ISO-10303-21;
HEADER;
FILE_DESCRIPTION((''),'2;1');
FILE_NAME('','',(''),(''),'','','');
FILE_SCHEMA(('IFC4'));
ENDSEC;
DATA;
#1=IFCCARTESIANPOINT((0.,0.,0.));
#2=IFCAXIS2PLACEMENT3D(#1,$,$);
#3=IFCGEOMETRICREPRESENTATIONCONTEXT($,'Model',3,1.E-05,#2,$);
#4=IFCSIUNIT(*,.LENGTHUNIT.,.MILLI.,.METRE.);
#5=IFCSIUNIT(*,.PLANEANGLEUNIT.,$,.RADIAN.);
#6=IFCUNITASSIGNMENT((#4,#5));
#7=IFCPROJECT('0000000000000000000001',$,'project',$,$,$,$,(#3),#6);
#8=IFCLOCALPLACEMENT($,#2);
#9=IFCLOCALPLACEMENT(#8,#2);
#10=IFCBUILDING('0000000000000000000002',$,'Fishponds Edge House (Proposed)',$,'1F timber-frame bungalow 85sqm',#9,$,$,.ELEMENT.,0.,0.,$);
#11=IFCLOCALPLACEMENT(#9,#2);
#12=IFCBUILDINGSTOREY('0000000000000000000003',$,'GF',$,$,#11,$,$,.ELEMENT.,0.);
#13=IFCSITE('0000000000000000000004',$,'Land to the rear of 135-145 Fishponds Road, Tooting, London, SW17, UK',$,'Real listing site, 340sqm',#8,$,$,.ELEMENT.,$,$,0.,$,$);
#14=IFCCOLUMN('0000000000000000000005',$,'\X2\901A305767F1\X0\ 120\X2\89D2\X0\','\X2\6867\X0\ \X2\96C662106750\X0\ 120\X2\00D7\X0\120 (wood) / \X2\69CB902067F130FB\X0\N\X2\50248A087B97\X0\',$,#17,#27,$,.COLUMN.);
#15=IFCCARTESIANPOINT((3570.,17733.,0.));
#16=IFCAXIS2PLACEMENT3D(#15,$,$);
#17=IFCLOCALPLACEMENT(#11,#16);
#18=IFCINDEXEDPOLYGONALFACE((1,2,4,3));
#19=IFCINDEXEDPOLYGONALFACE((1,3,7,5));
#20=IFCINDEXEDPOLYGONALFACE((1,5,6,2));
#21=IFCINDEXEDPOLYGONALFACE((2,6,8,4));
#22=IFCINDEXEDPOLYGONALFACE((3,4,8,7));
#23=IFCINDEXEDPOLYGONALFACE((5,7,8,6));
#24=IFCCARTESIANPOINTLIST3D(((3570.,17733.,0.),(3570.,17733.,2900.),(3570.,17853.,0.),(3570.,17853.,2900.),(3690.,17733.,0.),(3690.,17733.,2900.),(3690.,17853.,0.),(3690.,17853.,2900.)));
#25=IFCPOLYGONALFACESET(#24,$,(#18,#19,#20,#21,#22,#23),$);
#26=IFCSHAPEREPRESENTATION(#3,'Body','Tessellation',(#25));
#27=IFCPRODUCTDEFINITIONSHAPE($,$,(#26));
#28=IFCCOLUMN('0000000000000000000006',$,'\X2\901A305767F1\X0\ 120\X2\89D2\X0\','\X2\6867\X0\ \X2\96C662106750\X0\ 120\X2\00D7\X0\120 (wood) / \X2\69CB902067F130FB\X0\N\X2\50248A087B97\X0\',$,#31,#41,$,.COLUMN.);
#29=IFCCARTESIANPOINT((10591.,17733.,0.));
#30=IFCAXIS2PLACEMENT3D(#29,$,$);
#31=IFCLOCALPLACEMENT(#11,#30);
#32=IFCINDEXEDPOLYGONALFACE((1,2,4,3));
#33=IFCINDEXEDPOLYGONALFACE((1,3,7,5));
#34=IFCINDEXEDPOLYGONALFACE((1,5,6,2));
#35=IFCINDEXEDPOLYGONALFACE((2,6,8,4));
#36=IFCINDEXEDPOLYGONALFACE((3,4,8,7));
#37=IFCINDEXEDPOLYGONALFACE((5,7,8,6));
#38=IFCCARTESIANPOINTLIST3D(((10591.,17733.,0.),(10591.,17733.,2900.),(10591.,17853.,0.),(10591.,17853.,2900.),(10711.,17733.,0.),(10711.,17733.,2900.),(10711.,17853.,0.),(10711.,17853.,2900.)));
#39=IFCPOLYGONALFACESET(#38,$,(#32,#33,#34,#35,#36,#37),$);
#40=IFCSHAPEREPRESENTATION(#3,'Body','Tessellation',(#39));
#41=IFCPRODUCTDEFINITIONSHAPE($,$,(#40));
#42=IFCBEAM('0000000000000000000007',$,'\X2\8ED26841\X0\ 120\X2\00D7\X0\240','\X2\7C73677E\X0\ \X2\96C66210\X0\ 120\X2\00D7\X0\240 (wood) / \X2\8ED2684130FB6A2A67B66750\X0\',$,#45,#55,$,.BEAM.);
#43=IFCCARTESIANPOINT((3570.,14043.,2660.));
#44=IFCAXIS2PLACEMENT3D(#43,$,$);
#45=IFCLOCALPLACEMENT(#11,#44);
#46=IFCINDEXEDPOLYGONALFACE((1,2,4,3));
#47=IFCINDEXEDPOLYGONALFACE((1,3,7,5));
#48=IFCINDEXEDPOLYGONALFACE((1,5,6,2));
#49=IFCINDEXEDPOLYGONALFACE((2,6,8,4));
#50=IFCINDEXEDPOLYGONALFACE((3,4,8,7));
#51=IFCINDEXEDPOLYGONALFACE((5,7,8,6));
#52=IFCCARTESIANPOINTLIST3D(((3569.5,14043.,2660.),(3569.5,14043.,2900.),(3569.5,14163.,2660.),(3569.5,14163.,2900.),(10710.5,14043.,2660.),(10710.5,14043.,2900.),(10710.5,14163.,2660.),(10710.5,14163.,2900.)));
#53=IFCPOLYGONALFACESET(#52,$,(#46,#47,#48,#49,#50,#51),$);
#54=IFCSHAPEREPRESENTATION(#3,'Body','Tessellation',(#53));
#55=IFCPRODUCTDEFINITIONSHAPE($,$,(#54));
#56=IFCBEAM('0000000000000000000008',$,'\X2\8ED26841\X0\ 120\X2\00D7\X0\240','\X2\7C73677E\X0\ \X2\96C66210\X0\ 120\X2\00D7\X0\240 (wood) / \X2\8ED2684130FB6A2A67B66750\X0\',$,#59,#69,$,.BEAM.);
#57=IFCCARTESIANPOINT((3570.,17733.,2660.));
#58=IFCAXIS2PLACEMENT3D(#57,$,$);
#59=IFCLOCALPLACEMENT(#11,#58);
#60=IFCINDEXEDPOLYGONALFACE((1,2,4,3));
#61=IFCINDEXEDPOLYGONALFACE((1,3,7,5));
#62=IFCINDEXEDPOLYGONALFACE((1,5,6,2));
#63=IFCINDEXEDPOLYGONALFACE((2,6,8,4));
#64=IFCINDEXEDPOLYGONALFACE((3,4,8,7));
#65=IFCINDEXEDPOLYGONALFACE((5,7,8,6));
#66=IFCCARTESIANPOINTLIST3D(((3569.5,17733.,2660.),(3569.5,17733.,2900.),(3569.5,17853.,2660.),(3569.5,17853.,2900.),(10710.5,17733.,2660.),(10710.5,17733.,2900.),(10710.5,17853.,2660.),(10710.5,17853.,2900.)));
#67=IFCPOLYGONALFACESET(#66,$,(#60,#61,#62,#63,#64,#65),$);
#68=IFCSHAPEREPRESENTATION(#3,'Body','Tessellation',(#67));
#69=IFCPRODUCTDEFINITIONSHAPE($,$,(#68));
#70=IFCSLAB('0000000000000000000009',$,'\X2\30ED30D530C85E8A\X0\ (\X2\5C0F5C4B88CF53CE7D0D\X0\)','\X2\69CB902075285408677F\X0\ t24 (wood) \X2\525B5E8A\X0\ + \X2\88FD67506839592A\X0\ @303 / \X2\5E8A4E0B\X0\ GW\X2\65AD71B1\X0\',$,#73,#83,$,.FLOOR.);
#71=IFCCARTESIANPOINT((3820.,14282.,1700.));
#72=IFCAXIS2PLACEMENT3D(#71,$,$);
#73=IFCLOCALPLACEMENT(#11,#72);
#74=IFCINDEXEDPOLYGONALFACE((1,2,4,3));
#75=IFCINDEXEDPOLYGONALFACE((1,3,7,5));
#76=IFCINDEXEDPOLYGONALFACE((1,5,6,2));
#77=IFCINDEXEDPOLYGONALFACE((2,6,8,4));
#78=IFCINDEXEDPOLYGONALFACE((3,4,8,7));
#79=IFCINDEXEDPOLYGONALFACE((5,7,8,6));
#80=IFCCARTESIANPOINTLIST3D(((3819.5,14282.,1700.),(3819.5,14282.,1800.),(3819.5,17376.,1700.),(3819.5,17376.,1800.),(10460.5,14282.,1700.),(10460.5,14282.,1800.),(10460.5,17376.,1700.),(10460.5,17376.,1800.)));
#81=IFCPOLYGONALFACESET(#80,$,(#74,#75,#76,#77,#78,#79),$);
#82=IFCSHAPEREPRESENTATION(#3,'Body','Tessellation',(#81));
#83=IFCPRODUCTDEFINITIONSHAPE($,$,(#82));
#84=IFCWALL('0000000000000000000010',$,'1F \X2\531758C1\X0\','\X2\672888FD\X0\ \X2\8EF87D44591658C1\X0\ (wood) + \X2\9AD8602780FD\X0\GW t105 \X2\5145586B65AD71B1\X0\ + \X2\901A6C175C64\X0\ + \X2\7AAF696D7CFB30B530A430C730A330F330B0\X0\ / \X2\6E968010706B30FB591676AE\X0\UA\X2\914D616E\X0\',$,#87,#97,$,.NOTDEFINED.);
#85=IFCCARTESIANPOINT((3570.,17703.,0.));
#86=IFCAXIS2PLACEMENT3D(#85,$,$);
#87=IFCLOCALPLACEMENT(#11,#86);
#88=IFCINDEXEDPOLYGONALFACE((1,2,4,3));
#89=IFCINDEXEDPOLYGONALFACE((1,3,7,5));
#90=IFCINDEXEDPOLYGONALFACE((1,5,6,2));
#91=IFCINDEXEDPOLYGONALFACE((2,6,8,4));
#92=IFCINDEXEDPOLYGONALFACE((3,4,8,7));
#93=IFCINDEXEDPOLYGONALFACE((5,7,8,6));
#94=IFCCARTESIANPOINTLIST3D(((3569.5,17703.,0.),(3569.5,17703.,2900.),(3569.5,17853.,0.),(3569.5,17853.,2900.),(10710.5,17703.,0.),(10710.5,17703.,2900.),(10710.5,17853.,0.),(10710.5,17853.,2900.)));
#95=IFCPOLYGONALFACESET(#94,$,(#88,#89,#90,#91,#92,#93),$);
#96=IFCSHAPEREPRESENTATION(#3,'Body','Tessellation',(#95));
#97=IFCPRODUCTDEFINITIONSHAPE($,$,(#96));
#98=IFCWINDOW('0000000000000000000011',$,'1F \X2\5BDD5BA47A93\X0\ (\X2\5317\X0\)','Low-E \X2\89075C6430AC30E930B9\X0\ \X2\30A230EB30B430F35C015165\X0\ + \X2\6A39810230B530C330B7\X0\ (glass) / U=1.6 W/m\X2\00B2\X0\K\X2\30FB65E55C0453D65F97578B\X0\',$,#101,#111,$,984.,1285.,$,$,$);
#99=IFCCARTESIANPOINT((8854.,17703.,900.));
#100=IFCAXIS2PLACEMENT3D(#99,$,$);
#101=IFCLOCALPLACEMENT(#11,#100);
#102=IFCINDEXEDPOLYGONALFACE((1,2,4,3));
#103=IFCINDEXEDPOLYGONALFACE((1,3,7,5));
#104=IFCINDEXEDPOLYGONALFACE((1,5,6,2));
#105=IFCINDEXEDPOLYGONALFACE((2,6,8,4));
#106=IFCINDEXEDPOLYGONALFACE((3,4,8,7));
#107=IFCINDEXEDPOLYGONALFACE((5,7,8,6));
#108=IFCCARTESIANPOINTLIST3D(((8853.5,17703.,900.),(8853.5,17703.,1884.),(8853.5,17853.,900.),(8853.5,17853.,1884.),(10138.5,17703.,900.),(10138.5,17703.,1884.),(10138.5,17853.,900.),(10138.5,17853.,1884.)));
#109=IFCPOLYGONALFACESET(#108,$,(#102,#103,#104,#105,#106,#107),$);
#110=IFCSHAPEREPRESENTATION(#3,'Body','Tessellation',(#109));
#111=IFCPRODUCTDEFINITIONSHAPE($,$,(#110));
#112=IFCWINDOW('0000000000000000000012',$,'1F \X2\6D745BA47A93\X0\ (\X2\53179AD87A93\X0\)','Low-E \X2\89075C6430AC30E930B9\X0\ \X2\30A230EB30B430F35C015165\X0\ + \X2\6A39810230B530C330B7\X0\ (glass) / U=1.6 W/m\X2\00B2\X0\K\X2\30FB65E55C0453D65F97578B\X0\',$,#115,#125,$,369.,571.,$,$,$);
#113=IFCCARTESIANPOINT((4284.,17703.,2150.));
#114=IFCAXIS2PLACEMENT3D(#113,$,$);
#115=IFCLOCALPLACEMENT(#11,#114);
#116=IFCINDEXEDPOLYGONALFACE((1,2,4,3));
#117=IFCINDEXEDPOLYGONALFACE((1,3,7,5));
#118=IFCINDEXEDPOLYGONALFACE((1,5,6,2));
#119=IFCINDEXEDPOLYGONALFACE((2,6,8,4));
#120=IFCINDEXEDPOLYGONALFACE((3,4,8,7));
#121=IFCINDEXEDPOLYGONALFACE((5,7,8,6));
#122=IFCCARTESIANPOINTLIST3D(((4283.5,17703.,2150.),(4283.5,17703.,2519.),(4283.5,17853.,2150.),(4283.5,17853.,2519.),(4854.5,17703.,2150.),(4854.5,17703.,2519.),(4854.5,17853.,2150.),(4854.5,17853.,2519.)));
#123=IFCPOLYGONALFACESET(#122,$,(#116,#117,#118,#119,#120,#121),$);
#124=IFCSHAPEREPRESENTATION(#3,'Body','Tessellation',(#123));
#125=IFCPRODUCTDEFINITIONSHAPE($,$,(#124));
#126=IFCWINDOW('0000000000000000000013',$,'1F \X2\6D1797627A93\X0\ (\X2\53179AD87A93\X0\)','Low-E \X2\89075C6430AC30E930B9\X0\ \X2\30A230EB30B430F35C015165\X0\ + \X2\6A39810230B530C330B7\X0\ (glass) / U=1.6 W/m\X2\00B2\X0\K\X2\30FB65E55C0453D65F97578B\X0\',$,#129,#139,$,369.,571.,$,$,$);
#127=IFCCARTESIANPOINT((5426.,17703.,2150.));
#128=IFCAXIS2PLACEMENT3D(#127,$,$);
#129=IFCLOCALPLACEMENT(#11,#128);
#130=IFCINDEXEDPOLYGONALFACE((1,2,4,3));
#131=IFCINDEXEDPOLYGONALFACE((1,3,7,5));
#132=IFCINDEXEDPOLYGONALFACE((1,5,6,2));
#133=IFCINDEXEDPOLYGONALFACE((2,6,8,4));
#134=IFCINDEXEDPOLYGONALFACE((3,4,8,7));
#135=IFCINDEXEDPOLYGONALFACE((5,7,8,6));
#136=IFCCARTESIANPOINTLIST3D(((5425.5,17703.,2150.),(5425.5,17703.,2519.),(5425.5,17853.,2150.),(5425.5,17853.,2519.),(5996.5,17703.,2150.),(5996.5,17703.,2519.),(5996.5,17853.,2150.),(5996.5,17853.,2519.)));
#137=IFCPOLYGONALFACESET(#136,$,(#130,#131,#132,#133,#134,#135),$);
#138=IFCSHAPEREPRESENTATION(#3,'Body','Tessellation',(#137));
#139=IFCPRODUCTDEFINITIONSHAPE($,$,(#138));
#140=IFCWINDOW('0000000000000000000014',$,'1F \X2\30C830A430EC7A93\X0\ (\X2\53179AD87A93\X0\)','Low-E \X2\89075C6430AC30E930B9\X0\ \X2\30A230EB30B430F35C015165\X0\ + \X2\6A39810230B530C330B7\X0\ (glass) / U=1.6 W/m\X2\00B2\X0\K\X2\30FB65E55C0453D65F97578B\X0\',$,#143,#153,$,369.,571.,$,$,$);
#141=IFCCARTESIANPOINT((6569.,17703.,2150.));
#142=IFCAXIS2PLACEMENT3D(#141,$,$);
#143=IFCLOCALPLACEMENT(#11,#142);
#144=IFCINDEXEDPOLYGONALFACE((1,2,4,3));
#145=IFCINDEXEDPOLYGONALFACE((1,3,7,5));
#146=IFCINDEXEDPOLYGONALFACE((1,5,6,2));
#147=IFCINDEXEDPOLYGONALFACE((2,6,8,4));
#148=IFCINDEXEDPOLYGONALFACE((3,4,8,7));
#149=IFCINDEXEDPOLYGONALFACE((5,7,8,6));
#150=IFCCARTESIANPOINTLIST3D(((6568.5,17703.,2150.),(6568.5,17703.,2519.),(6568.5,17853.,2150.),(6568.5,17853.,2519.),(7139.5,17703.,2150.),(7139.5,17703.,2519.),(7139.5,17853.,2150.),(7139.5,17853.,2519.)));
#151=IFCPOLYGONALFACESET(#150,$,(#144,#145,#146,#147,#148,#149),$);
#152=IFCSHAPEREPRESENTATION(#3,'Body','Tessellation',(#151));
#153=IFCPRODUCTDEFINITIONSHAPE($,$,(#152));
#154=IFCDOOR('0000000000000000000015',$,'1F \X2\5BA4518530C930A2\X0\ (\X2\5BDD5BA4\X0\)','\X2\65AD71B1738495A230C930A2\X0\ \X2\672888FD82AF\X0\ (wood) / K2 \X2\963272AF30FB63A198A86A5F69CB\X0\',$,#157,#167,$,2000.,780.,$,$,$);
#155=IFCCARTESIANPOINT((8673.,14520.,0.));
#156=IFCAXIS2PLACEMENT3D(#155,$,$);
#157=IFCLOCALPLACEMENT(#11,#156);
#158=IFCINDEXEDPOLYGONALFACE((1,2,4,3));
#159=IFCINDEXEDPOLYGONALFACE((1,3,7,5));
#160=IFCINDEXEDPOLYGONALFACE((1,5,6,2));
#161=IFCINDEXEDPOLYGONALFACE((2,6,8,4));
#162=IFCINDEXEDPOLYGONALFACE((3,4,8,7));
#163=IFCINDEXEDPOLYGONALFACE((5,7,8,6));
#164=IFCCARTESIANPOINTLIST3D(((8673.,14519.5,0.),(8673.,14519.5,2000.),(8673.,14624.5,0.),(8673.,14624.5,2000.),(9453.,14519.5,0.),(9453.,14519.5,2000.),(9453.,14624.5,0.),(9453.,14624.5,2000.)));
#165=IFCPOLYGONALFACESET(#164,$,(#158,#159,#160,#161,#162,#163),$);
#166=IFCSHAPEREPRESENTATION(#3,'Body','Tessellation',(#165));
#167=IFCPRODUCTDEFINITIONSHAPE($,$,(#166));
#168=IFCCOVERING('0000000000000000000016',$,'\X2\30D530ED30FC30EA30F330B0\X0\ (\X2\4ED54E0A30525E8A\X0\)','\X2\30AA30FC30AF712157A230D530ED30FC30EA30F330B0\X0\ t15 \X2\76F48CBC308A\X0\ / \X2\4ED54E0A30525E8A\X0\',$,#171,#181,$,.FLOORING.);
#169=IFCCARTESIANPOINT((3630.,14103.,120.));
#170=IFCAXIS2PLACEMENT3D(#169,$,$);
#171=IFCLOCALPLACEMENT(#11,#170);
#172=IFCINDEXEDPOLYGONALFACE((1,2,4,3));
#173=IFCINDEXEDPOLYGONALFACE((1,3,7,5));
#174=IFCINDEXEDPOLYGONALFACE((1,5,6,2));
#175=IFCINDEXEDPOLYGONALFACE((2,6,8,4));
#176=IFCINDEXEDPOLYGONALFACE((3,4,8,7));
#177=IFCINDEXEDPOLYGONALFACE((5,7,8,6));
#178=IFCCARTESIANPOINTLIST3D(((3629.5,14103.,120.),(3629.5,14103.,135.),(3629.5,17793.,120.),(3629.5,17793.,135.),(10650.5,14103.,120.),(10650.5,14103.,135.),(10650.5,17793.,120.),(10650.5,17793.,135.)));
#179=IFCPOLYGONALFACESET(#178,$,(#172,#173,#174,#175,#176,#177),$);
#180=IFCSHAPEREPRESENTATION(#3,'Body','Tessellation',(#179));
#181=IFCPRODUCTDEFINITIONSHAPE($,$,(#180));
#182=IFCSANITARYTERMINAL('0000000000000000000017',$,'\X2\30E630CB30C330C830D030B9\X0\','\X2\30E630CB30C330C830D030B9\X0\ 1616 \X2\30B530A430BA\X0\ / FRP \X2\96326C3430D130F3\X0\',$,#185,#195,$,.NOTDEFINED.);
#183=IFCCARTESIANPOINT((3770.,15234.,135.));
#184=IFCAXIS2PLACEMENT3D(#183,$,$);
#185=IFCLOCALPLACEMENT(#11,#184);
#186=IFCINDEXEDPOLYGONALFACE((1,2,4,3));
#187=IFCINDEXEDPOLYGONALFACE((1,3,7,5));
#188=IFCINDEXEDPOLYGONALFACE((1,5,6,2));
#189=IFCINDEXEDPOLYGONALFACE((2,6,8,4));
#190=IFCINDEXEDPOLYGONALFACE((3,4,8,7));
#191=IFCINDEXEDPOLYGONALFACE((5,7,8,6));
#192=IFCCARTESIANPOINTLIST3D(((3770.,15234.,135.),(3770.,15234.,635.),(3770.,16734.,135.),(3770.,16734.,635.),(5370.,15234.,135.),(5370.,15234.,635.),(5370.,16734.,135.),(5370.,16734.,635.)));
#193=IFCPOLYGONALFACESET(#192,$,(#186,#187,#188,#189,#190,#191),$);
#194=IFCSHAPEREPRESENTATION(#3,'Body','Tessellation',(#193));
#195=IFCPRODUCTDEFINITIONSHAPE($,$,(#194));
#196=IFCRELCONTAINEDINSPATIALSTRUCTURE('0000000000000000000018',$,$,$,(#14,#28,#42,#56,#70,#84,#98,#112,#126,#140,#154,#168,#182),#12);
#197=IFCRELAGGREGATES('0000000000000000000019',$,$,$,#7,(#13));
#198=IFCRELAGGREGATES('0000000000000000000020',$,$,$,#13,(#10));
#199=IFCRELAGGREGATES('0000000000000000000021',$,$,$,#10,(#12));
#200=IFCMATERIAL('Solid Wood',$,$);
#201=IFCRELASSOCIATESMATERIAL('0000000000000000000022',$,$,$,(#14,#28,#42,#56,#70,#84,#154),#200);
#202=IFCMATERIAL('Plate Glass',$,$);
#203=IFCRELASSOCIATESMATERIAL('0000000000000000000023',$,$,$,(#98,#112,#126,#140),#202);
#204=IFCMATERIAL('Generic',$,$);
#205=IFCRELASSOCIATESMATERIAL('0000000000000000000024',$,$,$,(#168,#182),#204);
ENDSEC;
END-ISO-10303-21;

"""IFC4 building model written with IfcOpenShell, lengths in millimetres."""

from ifc_helpers import new_model, si_unit, frame, frame_2d, origin, place, context, project, spatial, rectangle, extrude, material, element, fill, save


model = new_model("IFC4")

# Units and contexts
model_context = context("Model", 3, precision=1e-05, world=origin())
ifc_project = project(units=[si_unit("LENGTHUNIT", "METRE", prefix="MILLI"), si_unit("PLANEANGLEUNIT", "RADIAN")], contexts=[model_context])

# Site, building, storey
site_placement = place(None, origin())
site = spatial("IfcSite", under=ifc_project, at=site_placement, Name="Land to the rear of 135-145 Fishponds Road, Tooting, London, SW17, UK", ObjectType="Real listing site, 340sqm", CompositionType="ELEMENT", RefElevation=0.0)
building_placement = place(site_placement, origin())
building = spatial("IfcBuilding", under=site, at=building_placement, Name="Fishponds Edge House (Proposed)", ObjectType="1F timber-frame bungalow 85sqm", CompositionType="ELEMENT", ElevationOfRefHeight=0.0, ElevationOfTerrain=0.0)
storey_placement = place(building_placement, origin())
storey = spatial("IfcBuildingStorey", under=building, at=storey_placement, Name="GF", CompositionType="ELEMENT", Elevation=0.0)

# Columns
ifc_material_1 = material(Name="Solid Wood")
column_1_placement = place(storey_placement, frame((3570.0, 17733.0, 0.0)))
element("IfcColumn", 1, at=column_1_placement, inside=storey, material=ifc_material_1, Name="通し柱 120角", Description="桧 集成材 120×120 (wood) / 構造柱・N値計算", PredefinedType="COLUMN", context=model_context, shape_type="SweptSolid", body=[
    extrude(rectangle(XDim=120.0, YDim=120.0, at=frame_2d((60.0, 60.0))), frame((3570.0, 17733.0, 0.0)), (0.0, 0.0, 1.0), 2900.0),
])
column_2_placement = place(storey_placement, frame((10591.0, 17733.0, 0.0)))
element("IfcColumn", 2, at=column_2_placement, inside=storey, material=ifc_material_1, Name="通し柱 120角", Description="桧 集成材 120×120 (wood) / 構造柱・N値計算", PredefinedType="COLUMN", context=model_context, shape_type="SweptSolid", body=[
    extrude(rectangle(XDim=120.0, YDim=120.0, at=frame_2d((60.0, 60.0))), frame((10591.0, 17733.0, 0.0)), (0.0, 0.0, 1.0), 2900.0),
])

# Beams
beam_1_placement = place(storey_placement, frame((3570.0, 14043.0, 2660.0)))
element("IfcBeam", 3, at=beam_1_placement, inside=storey, material=ifc_material_1, Name="軒桁 120×240", Description="米松 集成 120×240 (wood) / 軒桁・横架材", PredefinedType="BEAM", context=model_context, shape_type="SweptSolid", body=[
    extrude(rectangle(XDim=7141.0, YDim=120.0, at=frame_2d((3570.0, 60.0))), frame((3570.0, 14043.0, 2660.0)), (0.0, 0.0, 1.0), 240.0),
])
beam_2_placement = place(storey_placement, frame((3570.0, 17733.0, 2660.0)))
element("IfcBeam", 4, at=beam_2_placement, inside=storey, material=ifc_material_1, Name="軒桁 120×240", Description="米松 集成 120×240 (wood) / 軒桁・横架材", PredefinedType="BEAM", context=model_context, shape_type="SweptSolid", body=[
    extrude(rectangle(XDim=7141.0, YDim=120.0, at=frame_2d((3570.0, 60.0))), frame((3570.0, 17733.0, 2660.0)), (0.0, 0.0, 1.0), 240.0),
])

# Slab
slab_placement = place(storey_placement, frame((3820.0, 14282.0, 1700.0)))
element("IfcSlab", 5, at=slab_placement, inside=storey, material=ifc_material_1, Name="ロフト床 (小屋裏収納)", Description="構造用合板 t24 (wood) 剛床 + 製材根太 @303 / 床下 GW断熱", PredefinedType="FLOOR", context=model_context, shape_type="SweptSolid", body=[
    extrude(rectangle(XDim=6641.0, YDim=3094.0, at=frame_2d((3320.0, 1547.0))), frame((3820.0, 14282.0, 1700.0)), (0.0, 0.0, 1.0), 100.0),
])

# Wall, openings, windows
wall_1_placement = place(storey_placement, frame((3570.0, 17703.0, 0.0)))
wall_1 = element("IfcWall", 6, at=wall_1_placement, inside=storey, material=ifc_material_1, Name="1F 北壁", Description="木製 軸組外壁 (wood) + 高性能GW t105 充填断熱 + 通気層 + 窯業系サイディング / 準耐火・外皮UA配慮", PredefinedType="NOTDEFINED", context=model_context, shape_type="SweptSolid", body=[
    extrude(rectangle(XDim=7141.0, YDim=150.0, at=frame_2d((3570.0, 75.0))), frame((3570.0, 17703.0, 0.0)), (0.0, 0.0, 1.0), 2900.0),
])
opening_1_placement = place(storey_placement, frame((8854.0, 17703.0, 900.0)))
opening_1 = element("IfcOpeningElement", 7, at=opening_1_placement, cuts=wall_1, PredefinedType="NOTDEFINED", context=model_context, shape_type="SweptSolid", body=[
    extrude(rectangle(XDim=1285.0, YDim=150.0, at=frame_2d((642.0, 75.0))), frame((8854.0, 17703.0, 900.0)), (0.0, 0.0, 1.0), 984.0),
])
opening_2_placement = place(storey_placement, frame((4284.0, 17703.0, 2150.0)))
opening_2 = element("IfcOpeningElement", 8, at=opening_2_placement, cuts=wall_1, PredefinedType="NOTDEFINED", context=model_context, shape_type="SweptSolid", body=[
    extrude(rectangle(XDim=571.0, YDim=150.0, at=frame_2d((285.0, 75.0))), frame((4284.0, 17703.0, 2150.0)), (0.0, 0.0, 1.0), 369.0),
])
opening_3_placement = place(storey_placement, frame((5426.0, 17703.0, 2150.0)))
opening_3 = element("IfcOpeningElement", 9, at=opening_3_placement, cuts=wall_1, PredefinedType="NOTDEFINED", context=model_context, shape_type="SweptSolid", body=[
    extrude(rectangle(XDim=571.0, YDim=150.0, at=frame_2d((285.0, 75.0))), frame((5426.0, 17703.0, 2150.0)), (0.0, 0.0, 1.0), 369.0),
])
opening_4_placement = place(storey_placement, frame((6569.0, 17703.0, 2150.0)))
opening_4 = element("IfcOpeningElement", 10, at=opening_4_placement, cuts=wall_1, PredefinedType="NOTDEFINED", context=model_context, shape_type="SweptSolid", body=[
    extrude(rectangle(XDim=571.0, YDim=150.0, at=frame_2d((285.0, 75.0))), frame((6569.0, 17703.0, 2150.0)), (0.0, 0.0, 1.0), 369.0),
])
ifc_material_2 = material(Name="Plate Glass")
window_1_placement = place(storey_placement, frame((8854.0, 17703.0, 900.0)))
window_1 = element("IfcWindow", 11, at=window_1_placement, inside=storey, material=ifc_material_2, Name="1F 寝室窓 (北)", Description="Low-E 複層ガラス アルゴン封入 + 樹脂サッシ (glass) / U=1.6 W/m²K・日射取得型", OverallHeight=984.0, OverallWidth=1285.0, context=model_context, shape_type="SweptSolid", body=[
    extrude(rectangle(XDim=1285.0, YDim=150.0, at=frame_2d((642.0, 75.0))), frame((8854.0, 17703.0, 900.0)), (0.0, 0.0, 1.0), 984.0),
])
fill(opening_1, window_1)
window_2_placement = place(storey_placement, frame((4284.0, 17703.0, 2150.0)))
window_2 = element("IfcWindow", 12, at=window_2_placement, inside=storey, material=ifc_material_2, Name="1F 浴室窓 (北高窓)", Description="Low-E 複層ガラス アルゴン封入 + 樹脂サッシ (glass) / U=1.6 W/m²K・日射取得型", OverallHeight=369.0, OverallWidth=571.0, context=model_context, shape_type="SweptSolid", body=[
    extrude(rectangle(XDim=571.0, YDim=150.0, at=frame_2d((285.0, 75.0))), frame((4284.0, 17703.0, 2150.0)), (0.0, 0.0, 1.0), 369.0),
])
fill(opening_2, window_2)
window_3_placement = place(storey_placement, frame((5426.0, 17703.0, 2150.0)))
window_3 = element("IfcWindow", 13, at=window_3_placement, inside=storey, material=ifc_material_2, Name="1F 洗面窓 (北高窓)", Description="Low-E 複層ガラス アルゴン封入 + 樹脂サッシ (glass) / U=1.6 W/m²K・日射取得型", OverallHeight=369.0, OverallWidth=571.0, context=model_context, shape_type="SweptSolid", body=[
    extrude(rectangle(XDim=571.0, YDim=150.0, at=frame_2d((285.0, 75.0))), frame((5426.0, 17703.0, 2150.0)), (0.0, 0.0, 1.0), 369.0),
])
fill(opening_3, window_3)
window_4_placement = place(storey_placement, frame((6569.0, 17703.0, 2150.0)))
window_4 = element("IfcWindow", 14, at=window_4_placement, inside=storey, material=ifc_material_2, Name="1F トイレ窓 (北高窓)", Description="Low-E 複層ガラス アルゴン封入 + 樹脂サッシ (glass) / U=1.6 W/m²K・日射取得型", OverallHeight=369.0, OverallWidth=571.0, context=model_context, shape_type="SweptSolid", body=[
    extrude(rectangle(XDim=571.0, YDim=150.0, at=frame_2d((285.0, 75.0))), frame((6569.0, 17703.0, 2150.0)), (0.0, 0.0, 1.0), 369.0),
])
fill(opening_4, window_4)

# Door
door_1_placement = place(storey_placement, frame((8673.0, 14520.0, 0.0)))
element("IfcDoor", 15, at=door_1_placement, inside=storey, material=ifc_material_1, Name="1F 室内ドア (寝室)", Description="断熱玄関ドア 木製芯 (wood) / K2 防犯・採風機構", OverallHeight=2000.0, OverallWidth=780.0, context=model_context, shape_type="SweptSolid", body=[
    extrude(rectangle(XDim=780.0, YDim=105.0, at=frame_2d((390.0, 52.0))), frame((8673.0, 14520.0, 0.0)), (0.0, 0.0, 1.0), 2000.0),
])

# Covering
ifc_material_3 = material(Name="Generic")
covering_placement = place(storey_placement, frame((3630.0, 14103.0, 120.0)))
element("IfcCovering", 16, at=covering_placement, inside=storey, material=ifc_material_3, Name="フローリング (仕上げ床)", Description="オーク無垢フローリング t15 直貼り / 仕上げ床", PredefinedType="FLOORING", context=model_context, shape_type="SweptSolid", body=[
    extrude(rectangle(XDim=7021.0, YDim=3690.0, at=frame_2d((3510.0, 1845.0))), frame((3630.0, 14103.0, 120.0)), (0.0, 0.0, 1.0), 15.0),
])

# Sanitary terminal
sanitary_terminal_1_placement = place(storey_placement, frame((3770.0, 15234.0, 135.0)))
element("IfcSanitaryTerminal", 17, at=sanitary_terminal_1_placement, inside=storey, material=ifc_material_3, Name="ユニットバス", Description="ユニットバス 1616 サイズ / FRP 防水パン", PredefinedType="NOTDEFINED", context=model_context, shape_type="SweptSolid", body=[
    extrude(rectangle(XDim=1600.0, YDim=1500.0, at=frame_2d((800.0, 750.0))), frame((3770.0, 15234.0, 135.0)), (0.0, 0.0, 1.0), 500.0),
])

save(model, "model.ifc")
